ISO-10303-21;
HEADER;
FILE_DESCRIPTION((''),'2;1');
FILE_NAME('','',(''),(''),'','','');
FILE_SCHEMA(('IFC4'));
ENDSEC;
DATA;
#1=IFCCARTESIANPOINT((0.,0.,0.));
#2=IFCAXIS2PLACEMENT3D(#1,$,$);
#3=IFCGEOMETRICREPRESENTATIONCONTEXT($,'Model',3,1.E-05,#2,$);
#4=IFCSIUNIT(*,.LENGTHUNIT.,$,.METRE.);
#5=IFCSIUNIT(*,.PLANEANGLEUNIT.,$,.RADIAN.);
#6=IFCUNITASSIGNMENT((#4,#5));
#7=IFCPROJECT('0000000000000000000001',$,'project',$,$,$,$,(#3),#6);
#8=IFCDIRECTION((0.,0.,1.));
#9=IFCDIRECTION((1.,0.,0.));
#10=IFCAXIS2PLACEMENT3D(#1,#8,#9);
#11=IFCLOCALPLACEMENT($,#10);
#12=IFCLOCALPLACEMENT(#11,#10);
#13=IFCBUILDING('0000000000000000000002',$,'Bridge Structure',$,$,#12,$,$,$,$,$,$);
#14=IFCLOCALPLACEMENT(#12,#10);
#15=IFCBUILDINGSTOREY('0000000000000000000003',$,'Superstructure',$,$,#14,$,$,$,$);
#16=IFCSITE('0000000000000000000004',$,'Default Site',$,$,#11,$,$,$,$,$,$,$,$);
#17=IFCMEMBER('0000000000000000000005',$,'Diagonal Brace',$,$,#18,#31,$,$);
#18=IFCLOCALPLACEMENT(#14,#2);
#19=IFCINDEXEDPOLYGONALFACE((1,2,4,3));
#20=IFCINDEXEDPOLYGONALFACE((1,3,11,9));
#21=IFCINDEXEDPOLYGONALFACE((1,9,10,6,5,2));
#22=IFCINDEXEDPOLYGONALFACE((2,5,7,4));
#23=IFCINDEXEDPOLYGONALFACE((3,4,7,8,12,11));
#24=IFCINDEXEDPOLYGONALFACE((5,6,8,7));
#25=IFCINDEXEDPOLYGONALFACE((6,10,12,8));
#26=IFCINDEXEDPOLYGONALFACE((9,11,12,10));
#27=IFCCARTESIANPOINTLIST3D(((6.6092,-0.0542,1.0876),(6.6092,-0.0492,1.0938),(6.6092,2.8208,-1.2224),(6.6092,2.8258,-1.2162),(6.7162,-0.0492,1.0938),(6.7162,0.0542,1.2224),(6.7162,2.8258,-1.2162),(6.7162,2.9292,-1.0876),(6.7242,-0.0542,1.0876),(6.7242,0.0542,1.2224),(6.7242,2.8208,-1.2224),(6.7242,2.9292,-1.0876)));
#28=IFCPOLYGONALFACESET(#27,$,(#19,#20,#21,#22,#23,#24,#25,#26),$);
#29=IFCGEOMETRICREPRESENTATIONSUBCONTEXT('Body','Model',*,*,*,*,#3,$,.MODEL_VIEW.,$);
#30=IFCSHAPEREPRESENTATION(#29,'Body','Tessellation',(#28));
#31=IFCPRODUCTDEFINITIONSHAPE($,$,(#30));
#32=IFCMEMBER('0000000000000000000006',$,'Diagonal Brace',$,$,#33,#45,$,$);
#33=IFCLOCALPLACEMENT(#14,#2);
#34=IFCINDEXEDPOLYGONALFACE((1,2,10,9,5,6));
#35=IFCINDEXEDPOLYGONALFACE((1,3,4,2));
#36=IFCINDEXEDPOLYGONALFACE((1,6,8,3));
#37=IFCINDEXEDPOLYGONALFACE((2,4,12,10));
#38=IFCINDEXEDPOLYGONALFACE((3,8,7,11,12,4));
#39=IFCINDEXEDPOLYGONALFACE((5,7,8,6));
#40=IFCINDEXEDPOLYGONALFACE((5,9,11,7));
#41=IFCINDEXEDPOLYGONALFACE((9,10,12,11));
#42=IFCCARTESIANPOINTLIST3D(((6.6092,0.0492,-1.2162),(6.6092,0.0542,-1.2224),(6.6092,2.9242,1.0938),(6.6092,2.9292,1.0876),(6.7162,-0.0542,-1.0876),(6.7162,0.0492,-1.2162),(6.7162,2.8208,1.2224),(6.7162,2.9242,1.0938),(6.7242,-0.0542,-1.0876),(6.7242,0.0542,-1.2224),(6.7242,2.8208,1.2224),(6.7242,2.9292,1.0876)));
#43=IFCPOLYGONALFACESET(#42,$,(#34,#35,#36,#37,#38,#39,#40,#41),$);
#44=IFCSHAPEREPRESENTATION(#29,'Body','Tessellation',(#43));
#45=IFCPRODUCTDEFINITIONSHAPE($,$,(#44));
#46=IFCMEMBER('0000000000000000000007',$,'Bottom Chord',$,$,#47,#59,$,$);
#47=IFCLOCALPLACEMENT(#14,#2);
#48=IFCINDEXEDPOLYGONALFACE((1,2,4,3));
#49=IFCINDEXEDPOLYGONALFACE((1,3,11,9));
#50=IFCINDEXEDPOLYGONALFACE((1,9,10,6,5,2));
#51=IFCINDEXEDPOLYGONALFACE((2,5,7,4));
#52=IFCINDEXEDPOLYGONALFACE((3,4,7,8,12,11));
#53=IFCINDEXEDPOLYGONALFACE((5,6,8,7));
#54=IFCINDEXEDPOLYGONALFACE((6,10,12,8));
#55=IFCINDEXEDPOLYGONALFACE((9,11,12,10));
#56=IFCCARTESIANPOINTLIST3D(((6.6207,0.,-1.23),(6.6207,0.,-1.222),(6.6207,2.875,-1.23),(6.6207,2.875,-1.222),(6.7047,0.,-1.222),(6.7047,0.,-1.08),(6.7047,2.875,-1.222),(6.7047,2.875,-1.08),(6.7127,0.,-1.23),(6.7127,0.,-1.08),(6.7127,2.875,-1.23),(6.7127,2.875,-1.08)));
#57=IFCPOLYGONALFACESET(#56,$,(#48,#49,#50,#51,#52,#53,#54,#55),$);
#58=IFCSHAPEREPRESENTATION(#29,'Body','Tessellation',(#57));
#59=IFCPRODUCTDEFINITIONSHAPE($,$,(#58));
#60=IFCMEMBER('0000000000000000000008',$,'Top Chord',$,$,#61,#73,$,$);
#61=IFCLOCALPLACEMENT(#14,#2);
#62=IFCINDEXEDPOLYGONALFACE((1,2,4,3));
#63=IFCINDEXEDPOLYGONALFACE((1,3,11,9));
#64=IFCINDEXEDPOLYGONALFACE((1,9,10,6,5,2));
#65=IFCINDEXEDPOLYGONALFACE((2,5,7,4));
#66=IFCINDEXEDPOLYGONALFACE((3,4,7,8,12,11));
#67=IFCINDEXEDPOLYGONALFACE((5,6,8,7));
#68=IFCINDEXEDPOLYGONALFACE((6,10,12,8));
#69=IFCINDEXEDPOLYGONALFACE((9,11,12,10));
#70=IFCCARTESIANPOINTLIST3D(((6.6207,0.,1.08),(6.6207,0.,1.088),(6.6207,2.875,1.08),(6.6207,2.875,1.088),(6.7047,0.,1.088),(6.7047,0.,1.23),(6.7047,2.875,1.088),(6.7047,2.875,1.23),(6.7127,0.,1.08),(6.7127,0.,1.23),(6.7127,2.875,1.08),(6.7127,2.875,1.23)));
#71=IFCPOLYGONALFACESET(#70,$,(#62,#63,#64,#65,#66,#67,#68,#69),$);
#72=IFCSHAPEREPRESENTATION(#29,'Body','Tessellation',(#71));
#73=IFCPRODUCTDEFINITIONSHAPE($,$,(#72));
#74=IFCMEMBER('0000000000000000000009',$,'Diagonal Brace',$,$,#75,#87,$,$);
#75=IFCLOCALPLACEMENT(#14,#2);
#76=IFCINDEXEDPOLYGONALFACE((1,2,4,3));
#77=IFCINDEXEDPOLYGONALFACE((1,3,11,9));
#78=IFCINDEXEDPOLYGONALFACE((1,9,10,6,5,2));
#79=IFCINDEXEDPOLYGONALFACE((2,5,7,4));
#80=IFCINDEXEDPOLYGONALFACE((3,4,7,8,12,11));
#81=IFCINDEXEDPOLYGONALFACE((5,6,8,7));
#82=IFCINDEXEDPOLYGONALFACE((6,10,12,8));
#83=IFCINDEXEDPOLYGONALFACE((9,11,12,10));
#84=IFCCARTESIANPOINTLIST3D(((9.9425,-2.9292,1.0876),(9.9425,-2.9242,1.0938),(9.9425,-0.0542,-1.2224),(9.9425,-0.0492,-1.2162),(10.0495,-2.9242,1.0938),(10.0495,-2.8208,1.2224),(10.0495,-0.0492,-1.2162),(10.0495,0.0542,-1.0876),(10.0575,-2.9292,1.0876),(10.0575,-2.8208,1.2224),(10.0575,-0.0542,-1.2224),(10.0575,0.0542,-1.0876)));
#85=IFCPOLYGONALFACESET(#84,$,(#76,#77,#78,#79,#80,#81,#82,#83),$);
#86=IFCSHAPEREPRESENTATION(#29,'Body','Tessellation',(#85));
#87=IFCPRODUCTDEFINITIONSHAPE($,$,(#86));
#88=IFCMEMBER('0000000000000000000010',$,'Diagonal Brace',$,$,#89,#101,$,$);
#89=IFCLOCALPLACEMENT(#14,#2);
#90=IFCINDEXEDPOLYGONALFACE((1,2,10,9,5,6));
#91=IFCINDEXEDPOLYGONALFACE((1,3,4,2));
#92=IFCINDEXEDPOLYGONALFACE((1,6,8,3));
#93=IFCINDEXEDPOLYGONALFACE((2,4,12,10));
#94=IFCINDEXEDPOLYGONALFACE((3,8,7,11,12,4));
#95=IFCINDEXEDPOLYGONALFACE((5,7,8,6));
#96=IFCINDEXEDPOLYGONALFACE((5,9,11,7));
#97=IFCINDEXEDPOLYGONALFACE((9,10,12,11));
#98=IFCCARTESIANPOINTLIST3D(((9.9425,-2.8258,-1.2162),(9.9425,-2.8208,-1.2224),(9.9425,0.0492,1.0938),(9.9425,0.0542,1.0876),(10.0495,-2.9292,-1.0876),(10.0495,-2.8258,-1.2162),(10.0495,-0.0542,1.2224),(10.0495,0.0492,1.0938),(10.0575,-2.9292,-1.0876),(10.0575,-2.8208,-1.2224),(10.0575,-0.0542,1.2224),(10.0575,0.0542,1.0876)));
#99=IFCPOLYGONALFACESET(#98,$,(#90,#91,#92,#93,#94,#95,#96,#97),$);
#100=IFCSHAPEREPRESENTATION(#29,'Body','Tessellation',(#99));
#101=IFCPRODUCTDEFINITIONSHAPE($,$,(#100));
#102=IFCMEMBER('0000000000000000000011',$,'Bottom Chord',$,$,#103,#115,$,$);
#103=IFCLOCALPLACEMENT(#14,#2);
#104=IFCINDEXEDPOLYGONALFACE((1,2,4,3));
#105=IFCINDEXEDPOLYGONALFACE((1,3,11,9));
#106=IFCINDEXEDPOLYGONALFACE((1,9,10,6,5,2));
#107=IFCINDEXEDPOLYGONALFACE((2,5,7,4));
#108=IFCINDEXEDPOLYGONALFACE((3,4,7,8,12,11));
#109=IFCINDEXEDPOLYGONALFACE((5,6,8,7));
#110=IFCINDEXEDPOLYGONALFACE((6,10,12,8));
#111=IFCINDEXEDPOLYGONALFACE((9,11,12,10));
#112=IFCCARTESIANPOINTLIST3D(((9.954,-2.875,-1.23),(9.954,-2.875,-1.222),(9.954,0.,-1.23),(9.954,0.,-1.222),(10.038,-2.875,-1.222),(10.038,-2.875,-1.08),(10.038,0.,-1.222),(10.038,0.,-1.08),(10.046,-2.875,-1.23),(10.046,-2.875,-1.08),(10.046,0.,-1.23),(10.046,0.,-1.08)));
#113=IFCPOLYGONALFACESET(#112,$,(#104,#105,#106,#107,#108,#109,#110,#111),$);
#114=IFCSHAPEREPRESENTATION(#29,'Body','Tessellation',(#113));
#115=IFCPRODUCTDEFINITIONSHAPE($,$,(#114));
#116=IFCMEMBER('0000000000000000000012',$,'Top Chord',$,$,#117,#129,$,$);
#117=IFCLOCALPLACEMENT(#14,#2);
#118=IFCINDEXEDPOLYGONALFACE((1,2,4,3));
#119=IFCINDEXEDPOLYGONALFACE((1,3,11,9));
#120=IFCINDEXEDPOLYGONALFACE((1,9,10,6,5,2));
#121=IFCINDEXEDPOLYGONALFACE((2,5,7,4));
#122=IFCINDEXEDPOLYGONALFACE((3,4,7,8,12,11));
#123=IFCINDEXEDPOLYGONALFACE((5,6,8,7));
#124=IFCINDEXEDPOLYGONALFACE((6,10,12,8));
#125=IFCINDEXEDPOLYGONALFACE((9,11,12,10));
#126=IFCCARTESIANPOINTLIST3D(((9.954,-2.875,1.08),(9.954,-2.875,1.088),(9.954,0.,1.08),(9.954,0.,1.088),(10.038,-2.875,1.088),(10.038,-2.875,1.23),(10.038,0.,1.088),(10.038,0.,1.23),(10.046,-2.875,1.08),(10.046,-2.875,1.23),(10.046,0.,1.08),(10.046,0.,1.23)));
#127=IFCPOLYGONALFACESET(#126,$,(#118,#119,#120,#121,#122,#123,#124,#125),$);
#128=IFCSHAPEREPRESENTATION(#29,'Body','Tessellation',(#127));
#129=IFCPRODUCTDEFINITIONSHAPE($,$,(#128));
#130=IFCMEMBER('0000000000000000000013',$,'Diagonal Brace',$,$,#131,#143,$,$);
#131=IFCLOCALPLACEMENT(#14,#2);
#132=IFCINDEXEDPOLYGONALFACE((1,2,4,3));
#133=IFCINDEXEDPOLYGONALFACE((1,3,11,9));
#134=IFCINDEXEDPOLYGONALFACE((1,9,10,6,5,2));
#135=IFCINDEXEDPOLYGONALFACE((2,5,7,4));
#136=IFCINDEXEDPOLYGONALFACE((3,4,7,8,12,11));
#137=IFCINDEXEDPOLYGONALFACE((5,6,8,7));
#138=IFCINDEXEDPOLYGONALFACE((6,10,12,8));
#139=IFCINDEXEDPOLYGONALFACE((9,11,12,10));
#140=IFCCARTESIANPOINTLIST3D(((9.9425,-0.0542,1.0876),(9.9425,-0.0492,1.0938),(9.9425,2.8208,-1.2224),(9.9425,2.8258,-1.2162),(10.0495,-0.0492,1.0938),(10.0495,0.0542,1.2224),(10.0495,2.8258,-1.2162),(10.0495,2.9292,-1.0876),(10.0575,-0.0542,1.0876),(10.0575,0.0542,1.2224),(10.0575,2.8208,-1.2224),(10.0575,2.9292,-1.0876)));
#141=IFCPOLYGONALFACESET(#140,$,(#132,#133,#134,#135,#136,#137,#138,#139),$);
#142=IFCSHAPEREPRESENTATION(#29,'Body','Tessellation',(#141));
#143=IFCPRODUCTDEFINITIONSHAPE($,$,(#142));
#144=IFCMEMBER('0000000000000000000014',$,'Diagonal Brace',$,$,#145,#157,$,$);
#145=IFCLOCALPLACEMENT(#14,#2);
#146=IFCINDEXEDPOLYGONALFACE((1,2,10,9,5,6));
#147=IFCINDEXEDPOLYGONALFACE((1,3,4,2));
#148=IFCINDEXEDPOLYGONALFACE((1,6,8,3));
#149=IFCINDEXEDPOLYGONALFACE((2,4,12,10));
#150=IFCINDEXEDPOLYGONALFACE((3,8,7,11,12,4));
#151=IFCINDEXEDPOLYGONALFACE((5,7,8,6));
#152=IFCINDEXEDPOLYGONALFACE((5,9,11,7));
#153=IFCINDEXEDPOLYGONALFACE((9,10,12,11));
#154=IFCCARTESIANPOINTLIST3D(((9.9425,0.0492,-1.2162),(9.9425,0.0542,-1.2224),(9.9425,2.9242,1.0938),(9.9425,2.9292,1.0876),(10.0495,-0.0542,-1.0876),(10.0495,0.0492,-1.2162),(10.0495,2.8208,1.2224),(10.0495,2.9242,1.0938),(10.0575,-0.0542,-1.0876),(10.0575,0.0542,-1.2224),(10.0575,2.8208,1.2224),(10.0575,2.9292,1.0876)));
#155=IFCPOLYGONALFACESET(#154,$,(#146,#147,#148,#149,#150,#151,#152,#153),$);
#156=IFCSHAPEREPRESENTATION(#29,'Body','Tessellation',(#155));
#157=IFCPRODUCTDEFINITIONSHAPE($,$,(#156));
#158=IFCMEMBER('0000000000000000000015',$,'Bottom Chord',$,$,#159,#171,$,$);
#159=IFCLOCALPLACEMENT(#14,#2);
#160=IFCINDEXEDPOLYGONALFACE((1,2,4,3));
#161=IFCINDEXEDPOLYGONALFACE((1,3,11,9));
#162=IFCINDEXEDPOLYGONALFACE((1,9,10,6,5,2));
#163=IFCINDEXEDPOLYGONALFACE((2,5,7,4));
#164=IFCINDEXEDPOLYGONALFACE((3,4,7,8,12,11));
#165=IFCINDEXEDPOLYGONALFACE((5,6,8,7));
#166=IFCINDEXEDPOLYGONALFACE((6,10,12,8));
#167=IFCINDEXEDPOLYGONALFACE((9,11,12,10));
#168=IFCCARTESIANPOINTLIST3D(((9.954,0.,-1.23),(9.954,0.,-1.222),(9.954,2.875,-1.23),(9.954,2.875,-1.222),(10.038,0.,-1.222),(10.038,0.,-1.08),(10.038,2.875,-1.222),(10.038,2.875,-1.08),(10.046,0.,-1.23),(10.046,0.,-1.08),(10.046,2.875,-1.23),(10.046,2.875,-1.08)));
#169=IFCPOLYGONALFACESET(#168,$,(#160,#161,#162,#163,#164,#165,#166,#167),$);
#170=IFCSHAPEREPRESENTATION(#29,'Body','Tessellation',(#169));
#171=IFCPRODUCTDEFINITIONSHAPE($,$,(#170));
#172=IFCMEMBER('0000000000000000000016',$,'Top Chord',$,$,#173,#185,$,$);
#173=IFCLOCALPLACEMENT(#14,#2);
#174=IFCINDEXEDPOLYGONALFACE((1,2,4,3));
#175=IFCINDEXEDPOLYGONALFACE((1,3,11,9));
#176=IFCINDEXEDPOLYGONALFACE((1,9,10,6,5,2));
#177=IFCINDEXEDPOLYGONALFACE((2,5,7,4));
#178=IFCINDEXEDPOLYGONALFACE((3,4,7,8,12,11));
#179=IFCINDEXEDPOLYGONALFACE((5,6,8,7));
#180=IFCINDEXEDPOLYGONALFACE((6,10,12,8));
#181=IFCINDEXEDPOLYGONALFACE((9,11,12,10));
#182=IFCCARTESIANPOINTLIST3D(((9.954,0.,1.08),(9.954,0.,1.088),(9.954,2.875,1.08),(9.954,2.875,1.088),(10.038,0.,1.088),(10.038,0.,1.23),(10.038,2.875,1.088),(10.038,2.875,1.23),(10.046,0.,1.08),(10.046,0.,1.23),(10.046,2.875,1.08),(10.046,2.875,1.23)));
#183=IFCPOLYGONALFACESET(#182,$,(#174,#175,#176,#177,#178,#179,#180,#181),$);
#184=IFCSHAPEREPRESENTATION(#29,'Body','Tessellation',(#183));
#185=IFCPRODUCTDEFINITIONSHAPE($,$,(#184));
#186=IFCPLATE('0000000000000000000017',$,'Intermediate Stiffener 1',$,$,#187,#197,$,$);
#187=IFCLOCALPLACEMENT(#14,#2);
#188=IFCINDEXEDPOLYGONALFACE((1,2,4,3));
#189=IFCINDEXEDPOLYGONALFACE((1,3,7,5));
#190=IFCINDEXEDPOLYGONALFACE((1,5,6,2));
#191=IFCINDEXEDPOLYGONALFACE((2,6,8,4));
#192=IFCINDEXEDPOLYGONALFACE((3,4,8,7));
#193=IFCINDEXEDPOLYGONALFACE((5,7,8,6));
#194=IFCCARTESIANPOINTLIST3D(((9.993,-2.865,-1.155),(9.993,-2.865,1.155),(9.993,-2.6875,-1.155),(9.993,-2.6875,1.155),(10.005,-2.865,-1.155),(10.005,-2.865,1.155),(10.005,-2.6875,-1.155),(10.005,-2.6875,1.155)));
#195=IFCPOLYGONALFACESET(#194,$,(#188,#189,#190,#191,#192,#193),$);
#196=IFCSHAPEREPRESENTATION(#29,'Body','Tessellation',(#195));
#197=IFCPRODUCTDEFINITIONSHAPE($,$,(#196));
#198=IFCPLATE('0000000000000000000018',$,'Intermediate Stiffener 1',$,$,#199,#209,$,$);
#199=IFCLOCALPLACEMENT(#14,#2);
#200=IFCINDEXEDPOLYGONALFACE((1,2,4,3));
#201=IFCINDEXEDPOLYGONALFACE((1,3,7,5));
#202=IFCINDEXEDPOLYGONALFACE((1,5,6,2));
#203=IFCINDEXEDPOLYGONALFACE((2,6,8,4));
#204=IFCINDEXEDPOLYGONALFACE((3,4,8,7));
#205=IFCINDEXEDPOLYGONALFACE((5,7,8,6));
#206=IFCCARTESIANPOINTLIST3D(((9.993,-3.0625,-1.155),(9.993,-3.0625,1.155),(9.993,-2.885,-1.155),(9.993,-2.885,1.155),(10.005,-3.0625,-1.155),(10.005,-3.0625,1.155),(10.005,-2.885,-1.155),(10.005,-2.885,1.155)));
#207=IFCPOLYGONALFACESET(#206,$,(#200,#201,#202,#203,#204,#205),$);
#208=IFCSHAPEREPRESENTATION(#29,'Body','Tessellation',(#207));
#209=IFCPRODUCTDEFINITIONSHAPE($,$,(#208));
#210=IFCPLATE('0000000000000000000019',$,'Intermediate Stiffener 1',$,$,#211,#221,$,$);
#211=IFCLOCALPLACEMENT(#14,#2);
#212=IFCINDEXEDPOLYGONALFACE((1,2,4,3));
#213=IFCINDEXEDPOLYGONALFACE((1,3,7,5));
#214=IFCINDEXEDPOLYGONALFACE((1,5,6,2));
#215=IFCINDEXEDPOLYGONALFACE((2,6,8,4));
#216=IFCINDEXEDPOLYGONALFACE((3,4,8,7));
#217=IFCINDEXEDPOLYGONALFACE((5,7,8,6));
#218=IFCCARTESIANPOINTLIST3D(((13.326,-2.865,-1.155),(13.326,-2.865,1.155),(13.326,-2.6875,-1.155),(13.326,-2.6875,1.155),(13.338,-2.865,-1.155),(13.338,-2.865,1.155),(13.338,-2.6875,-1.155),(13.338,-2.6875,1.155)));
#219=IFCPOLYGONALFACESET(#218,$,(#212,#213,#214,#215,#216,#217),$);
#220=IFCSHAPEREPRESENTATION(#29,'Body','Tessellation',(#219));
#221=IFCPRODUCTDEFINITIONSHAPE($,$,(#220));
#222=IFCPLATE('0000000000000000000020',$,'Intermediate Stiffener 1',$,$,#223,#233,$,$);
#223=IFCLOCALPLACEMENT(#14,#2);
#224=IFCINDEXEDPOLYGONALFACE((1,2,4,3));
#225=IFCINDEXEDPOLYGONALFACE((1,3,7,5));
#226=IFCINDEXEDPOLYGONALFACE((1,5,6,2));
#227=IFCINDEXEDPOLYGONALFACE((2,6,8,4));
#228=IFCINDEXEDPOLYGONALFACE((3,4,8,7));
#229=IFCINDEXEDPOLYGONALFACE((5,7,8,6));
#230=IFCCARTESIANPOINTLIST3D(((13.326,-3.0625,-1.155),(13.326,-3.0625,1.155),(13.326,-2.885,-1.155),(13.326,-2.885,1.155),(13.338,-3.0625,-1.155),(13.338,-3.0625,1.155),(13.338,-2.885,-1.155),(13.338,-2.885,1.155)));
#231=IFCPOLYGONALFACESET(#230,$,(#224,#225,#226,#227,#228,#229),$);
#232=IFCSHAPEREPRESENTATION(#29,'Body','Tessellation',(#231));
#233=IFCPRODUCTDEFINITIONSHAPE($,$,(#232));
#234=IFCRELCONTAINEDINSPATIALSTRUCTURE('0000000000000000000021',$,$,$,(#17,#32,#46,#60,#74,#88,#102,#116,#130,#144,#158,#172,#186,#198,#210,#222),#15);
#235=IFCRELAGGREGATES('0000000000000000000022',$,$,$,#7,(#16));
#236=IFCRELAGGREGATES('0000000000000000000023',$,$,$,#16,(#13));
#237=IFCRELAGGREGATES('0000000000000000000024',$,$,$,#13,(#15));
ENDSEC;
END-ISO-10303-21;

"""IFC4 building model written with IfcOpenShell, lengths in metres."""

from ifc_helpers import new_model, si_unit, frame, origin, origin_with_axes, origin_2d_with_axis, place, context, subcontext, project, spatial, rectangle, l_section, extrude, element, save


model = new_model("IFC4")

# Units and contexts
model_context = context("Model", 3, precision=1e-05, world=origin())
body_context = subcontext(model_context, "Body", "Model", "MODEL_VIEW")
ifc_project = project(units=[si_unit("LENGTHUNIT", "METRE"), si_unit("PLANEANGLEUNIT", "RADIAN")], contexts=[model_context])

# Site, building, storey
site_placement = place(None, origin_with_axes())
site = spatial("IfcSite", under=ifc_project, at=site_placement, Name="Default Site")
building_placement = place(site_placement, origin_with_axes())
building = spatial("IfcBuilding", under=site, at=building_placement, Name="Bridge Structure")
storey_placement = place(building_placement, origin_with_axes())
storey = spatial("IfcBuildingStorey", under=building, at=storey_placement, Name="Superstructure")

# Members
for number, where, z_axis, x_axis, name in (
    (1, (6.6667, 0.0, 1.155), (0.0, 0.779544, -0.626347), (-1.0, 0.0, 0.0), "Diagonal Brace"),
    (2, (6.6667, 0.0, -1.155), (0.0, 0.779544, 0.626347), (-1.0, 0.0, 0.0), "Diagonal Brace"),
):
    element("IfcMember", number, at=place(storey_placement, frame(where, z_axis=z_axis, x_axis=x_axis)), inside=storey, Name=name, context=body_context, shape_type="SweptSolid", body=[
        extrude(l_section(Depth=0.173, Width=0.115, Thickness=0.008, at=origin_2d_with_axis()), origin_with_axes(), (0.0, 0.0, 1.0), 3.6881),
    ])
for number, where, z_axis, x_axis, name in (
    (3, (6.6667, 0.0, -1.155), (0.0, 1.0, 0.0), (-1.0, 0.0, 0.0), "Bottom Chord"),
    (4, (6.6667, 0.0, 1.155), (0.0, 1.0, 0.0), (-1.0, 0.0, 0.0), "Top Chord"),
):
    element("IfcMember", number, at=place(storey_placement, frame(where, z_axis=z_axis, x_axis=x_axis)), inside=storey, Name=name, context=body_context, shape_type="SweptSolid", body=[
        extrude(l_section(Depth=0.15, Width=0.092, Thickness=0.008, at=origin_2d_with_axis()), origin_with_axes(), (0.0, 0.0, 1.0), 2.875),
    ])
for number, where, z_axis, x_axis, name in (
    (5, (10.0, -2.875, 1.155), (0.0, 0.779544, -0.626347), (-1.0, 0.0, 0.0), "Diagonal Brace"),
    (6, (10.0, -2.875, -1.155), (0.0, 0.779544, 0.626347), (-1.0, 0.0, 0.0), "Diagonal Brace"),
):
    element("IfcMember", number, at=place(storey_placement, frame(where, z_axis=z_axis, x_axis=x_axis)), inside=storey, Name=name, context=body_context, shape_type="SweptSolid", body=[
        extrude(l_section(Depth=0.173, Width=0.115, Thickness=0.008, at=origin_2d_with_axis()), origin_with_axes(), (0.0, 0.0, 1.0), 3.6881),
    ])
for number, where, z_axis, x_axis, name in (
    (7, (10.0, -2.875, -1.155), (0.0, 1.0, 0.0), (-1.0, 0.0, 0.0), "Bottom Chord"),
    (8, (10.0, -2.875, 1.155), (0.0, 1.0, 0.0), (-1.0, 0.0, 0.0), "Top Chord"),
):
    element("IfcMember", number, at=place(storey_placement, frame(where, z_axis=z_axis, x_axis=x_axis)), inside=storey, Name=name, context=body_context, shape_type="SweptSolid", body=[
        extrude(l_section(Depth=0.15, Width=0.092, Thickness=0.008, at=origin_2d_with_axis()), origin_with_axes(), (0.0, 0.0, 1.0), 2.875),
    ])
for number, where, z_axis, x_axis, name in (
    (9, (10.0, 0.0, 1.155), (0.0, 0.779544, -0.626347), (-1.0, 0.0, 0.0), "Diagonal Brace"),
    (10, (10.0, 0.0, -1.155), (0.0, 0.779544, 0.626347), (-1.0, 0.0, 0.0), "Diagonal Brace"),
):
    element("IfcMember", number, at=place(storey_placement, frame(where, z_axis=z_axis, x_axis=x_axis)), inside=storey, Name=name, context=body_context, shape_type="SweptSolid", body=[
        extrude(l_section(Depth=0.173, Width=0.115, Thickness=0.008, at=origin_2d_with_axis()), origin_with_axes(), (0.0, 0.0, 1.0), 3.6881),
    ])
for number, where, z_axis, x_axis, name in (
    (11, (10.0, 0.0, -1.155), (0.0, 1.0, 0.0), (-1.0, 0.0, 0.0), "Bottom Chord"),
    (12, (10.0, 0.0, 1.155), (0.0, 1.0, 0.0), (-1.0, 0.0, 0.0), "Top Chord"),
):
    element("IfcMember", number, at=place(storey_placement, frame(where, z_axis=z_axis, x_axis=x_axis)), inside=storey, Name=name, context=body_context, shape_type="SweptSolid", body=[
        extrude(l_section(Depth=0.15, Width=0.092, Thickness=0.008, at=origin_2d_with_axis()), origin_with_axes(), (0.0, 0.0, 1.0), 2.875),
    ])

# Plates
for number, where, z_axis, x_axis, name in (
    (13, (9.999, -2.7763, -1.155), (0.0, 0.0, 1.0), (1.0, 0.0, 0.0), "Intermediate Stiffener 1"),
    (14, (9.999, -2.9737, -1.155), (0.0, 0.0, 1.0), (1.0, 0.0, 0.0), "Intermediate Stiffener 1"),
    (15, (13.332, -2.7763, -1.155), (0.0, 0.0, 1.0), (1.0, 0.0, 0.0), "Intermediate Stiffener 1"),
    (16, (13.332, -2.9737, -1.155), (0.0, 0.0, 1.0), (1.0, 0.0, 0.0), "Intermediate Stiffener 1"),
):
    element("IfcPlate", number, at=place(storey_placement, frame(where, z_axis=z_axis, x_axis=x_axis)), inside=storey, Name=name, context=body_context, shape_type="SweptSolid", body=[
        extrude(rectangle(XDim=0.012, YDim=0.1775, at=origin_2d_with_axis()), origin_with_axes(), (0.0, 0.0, 1.0), 2.31),
    ])

save(model, "model.ifc")
